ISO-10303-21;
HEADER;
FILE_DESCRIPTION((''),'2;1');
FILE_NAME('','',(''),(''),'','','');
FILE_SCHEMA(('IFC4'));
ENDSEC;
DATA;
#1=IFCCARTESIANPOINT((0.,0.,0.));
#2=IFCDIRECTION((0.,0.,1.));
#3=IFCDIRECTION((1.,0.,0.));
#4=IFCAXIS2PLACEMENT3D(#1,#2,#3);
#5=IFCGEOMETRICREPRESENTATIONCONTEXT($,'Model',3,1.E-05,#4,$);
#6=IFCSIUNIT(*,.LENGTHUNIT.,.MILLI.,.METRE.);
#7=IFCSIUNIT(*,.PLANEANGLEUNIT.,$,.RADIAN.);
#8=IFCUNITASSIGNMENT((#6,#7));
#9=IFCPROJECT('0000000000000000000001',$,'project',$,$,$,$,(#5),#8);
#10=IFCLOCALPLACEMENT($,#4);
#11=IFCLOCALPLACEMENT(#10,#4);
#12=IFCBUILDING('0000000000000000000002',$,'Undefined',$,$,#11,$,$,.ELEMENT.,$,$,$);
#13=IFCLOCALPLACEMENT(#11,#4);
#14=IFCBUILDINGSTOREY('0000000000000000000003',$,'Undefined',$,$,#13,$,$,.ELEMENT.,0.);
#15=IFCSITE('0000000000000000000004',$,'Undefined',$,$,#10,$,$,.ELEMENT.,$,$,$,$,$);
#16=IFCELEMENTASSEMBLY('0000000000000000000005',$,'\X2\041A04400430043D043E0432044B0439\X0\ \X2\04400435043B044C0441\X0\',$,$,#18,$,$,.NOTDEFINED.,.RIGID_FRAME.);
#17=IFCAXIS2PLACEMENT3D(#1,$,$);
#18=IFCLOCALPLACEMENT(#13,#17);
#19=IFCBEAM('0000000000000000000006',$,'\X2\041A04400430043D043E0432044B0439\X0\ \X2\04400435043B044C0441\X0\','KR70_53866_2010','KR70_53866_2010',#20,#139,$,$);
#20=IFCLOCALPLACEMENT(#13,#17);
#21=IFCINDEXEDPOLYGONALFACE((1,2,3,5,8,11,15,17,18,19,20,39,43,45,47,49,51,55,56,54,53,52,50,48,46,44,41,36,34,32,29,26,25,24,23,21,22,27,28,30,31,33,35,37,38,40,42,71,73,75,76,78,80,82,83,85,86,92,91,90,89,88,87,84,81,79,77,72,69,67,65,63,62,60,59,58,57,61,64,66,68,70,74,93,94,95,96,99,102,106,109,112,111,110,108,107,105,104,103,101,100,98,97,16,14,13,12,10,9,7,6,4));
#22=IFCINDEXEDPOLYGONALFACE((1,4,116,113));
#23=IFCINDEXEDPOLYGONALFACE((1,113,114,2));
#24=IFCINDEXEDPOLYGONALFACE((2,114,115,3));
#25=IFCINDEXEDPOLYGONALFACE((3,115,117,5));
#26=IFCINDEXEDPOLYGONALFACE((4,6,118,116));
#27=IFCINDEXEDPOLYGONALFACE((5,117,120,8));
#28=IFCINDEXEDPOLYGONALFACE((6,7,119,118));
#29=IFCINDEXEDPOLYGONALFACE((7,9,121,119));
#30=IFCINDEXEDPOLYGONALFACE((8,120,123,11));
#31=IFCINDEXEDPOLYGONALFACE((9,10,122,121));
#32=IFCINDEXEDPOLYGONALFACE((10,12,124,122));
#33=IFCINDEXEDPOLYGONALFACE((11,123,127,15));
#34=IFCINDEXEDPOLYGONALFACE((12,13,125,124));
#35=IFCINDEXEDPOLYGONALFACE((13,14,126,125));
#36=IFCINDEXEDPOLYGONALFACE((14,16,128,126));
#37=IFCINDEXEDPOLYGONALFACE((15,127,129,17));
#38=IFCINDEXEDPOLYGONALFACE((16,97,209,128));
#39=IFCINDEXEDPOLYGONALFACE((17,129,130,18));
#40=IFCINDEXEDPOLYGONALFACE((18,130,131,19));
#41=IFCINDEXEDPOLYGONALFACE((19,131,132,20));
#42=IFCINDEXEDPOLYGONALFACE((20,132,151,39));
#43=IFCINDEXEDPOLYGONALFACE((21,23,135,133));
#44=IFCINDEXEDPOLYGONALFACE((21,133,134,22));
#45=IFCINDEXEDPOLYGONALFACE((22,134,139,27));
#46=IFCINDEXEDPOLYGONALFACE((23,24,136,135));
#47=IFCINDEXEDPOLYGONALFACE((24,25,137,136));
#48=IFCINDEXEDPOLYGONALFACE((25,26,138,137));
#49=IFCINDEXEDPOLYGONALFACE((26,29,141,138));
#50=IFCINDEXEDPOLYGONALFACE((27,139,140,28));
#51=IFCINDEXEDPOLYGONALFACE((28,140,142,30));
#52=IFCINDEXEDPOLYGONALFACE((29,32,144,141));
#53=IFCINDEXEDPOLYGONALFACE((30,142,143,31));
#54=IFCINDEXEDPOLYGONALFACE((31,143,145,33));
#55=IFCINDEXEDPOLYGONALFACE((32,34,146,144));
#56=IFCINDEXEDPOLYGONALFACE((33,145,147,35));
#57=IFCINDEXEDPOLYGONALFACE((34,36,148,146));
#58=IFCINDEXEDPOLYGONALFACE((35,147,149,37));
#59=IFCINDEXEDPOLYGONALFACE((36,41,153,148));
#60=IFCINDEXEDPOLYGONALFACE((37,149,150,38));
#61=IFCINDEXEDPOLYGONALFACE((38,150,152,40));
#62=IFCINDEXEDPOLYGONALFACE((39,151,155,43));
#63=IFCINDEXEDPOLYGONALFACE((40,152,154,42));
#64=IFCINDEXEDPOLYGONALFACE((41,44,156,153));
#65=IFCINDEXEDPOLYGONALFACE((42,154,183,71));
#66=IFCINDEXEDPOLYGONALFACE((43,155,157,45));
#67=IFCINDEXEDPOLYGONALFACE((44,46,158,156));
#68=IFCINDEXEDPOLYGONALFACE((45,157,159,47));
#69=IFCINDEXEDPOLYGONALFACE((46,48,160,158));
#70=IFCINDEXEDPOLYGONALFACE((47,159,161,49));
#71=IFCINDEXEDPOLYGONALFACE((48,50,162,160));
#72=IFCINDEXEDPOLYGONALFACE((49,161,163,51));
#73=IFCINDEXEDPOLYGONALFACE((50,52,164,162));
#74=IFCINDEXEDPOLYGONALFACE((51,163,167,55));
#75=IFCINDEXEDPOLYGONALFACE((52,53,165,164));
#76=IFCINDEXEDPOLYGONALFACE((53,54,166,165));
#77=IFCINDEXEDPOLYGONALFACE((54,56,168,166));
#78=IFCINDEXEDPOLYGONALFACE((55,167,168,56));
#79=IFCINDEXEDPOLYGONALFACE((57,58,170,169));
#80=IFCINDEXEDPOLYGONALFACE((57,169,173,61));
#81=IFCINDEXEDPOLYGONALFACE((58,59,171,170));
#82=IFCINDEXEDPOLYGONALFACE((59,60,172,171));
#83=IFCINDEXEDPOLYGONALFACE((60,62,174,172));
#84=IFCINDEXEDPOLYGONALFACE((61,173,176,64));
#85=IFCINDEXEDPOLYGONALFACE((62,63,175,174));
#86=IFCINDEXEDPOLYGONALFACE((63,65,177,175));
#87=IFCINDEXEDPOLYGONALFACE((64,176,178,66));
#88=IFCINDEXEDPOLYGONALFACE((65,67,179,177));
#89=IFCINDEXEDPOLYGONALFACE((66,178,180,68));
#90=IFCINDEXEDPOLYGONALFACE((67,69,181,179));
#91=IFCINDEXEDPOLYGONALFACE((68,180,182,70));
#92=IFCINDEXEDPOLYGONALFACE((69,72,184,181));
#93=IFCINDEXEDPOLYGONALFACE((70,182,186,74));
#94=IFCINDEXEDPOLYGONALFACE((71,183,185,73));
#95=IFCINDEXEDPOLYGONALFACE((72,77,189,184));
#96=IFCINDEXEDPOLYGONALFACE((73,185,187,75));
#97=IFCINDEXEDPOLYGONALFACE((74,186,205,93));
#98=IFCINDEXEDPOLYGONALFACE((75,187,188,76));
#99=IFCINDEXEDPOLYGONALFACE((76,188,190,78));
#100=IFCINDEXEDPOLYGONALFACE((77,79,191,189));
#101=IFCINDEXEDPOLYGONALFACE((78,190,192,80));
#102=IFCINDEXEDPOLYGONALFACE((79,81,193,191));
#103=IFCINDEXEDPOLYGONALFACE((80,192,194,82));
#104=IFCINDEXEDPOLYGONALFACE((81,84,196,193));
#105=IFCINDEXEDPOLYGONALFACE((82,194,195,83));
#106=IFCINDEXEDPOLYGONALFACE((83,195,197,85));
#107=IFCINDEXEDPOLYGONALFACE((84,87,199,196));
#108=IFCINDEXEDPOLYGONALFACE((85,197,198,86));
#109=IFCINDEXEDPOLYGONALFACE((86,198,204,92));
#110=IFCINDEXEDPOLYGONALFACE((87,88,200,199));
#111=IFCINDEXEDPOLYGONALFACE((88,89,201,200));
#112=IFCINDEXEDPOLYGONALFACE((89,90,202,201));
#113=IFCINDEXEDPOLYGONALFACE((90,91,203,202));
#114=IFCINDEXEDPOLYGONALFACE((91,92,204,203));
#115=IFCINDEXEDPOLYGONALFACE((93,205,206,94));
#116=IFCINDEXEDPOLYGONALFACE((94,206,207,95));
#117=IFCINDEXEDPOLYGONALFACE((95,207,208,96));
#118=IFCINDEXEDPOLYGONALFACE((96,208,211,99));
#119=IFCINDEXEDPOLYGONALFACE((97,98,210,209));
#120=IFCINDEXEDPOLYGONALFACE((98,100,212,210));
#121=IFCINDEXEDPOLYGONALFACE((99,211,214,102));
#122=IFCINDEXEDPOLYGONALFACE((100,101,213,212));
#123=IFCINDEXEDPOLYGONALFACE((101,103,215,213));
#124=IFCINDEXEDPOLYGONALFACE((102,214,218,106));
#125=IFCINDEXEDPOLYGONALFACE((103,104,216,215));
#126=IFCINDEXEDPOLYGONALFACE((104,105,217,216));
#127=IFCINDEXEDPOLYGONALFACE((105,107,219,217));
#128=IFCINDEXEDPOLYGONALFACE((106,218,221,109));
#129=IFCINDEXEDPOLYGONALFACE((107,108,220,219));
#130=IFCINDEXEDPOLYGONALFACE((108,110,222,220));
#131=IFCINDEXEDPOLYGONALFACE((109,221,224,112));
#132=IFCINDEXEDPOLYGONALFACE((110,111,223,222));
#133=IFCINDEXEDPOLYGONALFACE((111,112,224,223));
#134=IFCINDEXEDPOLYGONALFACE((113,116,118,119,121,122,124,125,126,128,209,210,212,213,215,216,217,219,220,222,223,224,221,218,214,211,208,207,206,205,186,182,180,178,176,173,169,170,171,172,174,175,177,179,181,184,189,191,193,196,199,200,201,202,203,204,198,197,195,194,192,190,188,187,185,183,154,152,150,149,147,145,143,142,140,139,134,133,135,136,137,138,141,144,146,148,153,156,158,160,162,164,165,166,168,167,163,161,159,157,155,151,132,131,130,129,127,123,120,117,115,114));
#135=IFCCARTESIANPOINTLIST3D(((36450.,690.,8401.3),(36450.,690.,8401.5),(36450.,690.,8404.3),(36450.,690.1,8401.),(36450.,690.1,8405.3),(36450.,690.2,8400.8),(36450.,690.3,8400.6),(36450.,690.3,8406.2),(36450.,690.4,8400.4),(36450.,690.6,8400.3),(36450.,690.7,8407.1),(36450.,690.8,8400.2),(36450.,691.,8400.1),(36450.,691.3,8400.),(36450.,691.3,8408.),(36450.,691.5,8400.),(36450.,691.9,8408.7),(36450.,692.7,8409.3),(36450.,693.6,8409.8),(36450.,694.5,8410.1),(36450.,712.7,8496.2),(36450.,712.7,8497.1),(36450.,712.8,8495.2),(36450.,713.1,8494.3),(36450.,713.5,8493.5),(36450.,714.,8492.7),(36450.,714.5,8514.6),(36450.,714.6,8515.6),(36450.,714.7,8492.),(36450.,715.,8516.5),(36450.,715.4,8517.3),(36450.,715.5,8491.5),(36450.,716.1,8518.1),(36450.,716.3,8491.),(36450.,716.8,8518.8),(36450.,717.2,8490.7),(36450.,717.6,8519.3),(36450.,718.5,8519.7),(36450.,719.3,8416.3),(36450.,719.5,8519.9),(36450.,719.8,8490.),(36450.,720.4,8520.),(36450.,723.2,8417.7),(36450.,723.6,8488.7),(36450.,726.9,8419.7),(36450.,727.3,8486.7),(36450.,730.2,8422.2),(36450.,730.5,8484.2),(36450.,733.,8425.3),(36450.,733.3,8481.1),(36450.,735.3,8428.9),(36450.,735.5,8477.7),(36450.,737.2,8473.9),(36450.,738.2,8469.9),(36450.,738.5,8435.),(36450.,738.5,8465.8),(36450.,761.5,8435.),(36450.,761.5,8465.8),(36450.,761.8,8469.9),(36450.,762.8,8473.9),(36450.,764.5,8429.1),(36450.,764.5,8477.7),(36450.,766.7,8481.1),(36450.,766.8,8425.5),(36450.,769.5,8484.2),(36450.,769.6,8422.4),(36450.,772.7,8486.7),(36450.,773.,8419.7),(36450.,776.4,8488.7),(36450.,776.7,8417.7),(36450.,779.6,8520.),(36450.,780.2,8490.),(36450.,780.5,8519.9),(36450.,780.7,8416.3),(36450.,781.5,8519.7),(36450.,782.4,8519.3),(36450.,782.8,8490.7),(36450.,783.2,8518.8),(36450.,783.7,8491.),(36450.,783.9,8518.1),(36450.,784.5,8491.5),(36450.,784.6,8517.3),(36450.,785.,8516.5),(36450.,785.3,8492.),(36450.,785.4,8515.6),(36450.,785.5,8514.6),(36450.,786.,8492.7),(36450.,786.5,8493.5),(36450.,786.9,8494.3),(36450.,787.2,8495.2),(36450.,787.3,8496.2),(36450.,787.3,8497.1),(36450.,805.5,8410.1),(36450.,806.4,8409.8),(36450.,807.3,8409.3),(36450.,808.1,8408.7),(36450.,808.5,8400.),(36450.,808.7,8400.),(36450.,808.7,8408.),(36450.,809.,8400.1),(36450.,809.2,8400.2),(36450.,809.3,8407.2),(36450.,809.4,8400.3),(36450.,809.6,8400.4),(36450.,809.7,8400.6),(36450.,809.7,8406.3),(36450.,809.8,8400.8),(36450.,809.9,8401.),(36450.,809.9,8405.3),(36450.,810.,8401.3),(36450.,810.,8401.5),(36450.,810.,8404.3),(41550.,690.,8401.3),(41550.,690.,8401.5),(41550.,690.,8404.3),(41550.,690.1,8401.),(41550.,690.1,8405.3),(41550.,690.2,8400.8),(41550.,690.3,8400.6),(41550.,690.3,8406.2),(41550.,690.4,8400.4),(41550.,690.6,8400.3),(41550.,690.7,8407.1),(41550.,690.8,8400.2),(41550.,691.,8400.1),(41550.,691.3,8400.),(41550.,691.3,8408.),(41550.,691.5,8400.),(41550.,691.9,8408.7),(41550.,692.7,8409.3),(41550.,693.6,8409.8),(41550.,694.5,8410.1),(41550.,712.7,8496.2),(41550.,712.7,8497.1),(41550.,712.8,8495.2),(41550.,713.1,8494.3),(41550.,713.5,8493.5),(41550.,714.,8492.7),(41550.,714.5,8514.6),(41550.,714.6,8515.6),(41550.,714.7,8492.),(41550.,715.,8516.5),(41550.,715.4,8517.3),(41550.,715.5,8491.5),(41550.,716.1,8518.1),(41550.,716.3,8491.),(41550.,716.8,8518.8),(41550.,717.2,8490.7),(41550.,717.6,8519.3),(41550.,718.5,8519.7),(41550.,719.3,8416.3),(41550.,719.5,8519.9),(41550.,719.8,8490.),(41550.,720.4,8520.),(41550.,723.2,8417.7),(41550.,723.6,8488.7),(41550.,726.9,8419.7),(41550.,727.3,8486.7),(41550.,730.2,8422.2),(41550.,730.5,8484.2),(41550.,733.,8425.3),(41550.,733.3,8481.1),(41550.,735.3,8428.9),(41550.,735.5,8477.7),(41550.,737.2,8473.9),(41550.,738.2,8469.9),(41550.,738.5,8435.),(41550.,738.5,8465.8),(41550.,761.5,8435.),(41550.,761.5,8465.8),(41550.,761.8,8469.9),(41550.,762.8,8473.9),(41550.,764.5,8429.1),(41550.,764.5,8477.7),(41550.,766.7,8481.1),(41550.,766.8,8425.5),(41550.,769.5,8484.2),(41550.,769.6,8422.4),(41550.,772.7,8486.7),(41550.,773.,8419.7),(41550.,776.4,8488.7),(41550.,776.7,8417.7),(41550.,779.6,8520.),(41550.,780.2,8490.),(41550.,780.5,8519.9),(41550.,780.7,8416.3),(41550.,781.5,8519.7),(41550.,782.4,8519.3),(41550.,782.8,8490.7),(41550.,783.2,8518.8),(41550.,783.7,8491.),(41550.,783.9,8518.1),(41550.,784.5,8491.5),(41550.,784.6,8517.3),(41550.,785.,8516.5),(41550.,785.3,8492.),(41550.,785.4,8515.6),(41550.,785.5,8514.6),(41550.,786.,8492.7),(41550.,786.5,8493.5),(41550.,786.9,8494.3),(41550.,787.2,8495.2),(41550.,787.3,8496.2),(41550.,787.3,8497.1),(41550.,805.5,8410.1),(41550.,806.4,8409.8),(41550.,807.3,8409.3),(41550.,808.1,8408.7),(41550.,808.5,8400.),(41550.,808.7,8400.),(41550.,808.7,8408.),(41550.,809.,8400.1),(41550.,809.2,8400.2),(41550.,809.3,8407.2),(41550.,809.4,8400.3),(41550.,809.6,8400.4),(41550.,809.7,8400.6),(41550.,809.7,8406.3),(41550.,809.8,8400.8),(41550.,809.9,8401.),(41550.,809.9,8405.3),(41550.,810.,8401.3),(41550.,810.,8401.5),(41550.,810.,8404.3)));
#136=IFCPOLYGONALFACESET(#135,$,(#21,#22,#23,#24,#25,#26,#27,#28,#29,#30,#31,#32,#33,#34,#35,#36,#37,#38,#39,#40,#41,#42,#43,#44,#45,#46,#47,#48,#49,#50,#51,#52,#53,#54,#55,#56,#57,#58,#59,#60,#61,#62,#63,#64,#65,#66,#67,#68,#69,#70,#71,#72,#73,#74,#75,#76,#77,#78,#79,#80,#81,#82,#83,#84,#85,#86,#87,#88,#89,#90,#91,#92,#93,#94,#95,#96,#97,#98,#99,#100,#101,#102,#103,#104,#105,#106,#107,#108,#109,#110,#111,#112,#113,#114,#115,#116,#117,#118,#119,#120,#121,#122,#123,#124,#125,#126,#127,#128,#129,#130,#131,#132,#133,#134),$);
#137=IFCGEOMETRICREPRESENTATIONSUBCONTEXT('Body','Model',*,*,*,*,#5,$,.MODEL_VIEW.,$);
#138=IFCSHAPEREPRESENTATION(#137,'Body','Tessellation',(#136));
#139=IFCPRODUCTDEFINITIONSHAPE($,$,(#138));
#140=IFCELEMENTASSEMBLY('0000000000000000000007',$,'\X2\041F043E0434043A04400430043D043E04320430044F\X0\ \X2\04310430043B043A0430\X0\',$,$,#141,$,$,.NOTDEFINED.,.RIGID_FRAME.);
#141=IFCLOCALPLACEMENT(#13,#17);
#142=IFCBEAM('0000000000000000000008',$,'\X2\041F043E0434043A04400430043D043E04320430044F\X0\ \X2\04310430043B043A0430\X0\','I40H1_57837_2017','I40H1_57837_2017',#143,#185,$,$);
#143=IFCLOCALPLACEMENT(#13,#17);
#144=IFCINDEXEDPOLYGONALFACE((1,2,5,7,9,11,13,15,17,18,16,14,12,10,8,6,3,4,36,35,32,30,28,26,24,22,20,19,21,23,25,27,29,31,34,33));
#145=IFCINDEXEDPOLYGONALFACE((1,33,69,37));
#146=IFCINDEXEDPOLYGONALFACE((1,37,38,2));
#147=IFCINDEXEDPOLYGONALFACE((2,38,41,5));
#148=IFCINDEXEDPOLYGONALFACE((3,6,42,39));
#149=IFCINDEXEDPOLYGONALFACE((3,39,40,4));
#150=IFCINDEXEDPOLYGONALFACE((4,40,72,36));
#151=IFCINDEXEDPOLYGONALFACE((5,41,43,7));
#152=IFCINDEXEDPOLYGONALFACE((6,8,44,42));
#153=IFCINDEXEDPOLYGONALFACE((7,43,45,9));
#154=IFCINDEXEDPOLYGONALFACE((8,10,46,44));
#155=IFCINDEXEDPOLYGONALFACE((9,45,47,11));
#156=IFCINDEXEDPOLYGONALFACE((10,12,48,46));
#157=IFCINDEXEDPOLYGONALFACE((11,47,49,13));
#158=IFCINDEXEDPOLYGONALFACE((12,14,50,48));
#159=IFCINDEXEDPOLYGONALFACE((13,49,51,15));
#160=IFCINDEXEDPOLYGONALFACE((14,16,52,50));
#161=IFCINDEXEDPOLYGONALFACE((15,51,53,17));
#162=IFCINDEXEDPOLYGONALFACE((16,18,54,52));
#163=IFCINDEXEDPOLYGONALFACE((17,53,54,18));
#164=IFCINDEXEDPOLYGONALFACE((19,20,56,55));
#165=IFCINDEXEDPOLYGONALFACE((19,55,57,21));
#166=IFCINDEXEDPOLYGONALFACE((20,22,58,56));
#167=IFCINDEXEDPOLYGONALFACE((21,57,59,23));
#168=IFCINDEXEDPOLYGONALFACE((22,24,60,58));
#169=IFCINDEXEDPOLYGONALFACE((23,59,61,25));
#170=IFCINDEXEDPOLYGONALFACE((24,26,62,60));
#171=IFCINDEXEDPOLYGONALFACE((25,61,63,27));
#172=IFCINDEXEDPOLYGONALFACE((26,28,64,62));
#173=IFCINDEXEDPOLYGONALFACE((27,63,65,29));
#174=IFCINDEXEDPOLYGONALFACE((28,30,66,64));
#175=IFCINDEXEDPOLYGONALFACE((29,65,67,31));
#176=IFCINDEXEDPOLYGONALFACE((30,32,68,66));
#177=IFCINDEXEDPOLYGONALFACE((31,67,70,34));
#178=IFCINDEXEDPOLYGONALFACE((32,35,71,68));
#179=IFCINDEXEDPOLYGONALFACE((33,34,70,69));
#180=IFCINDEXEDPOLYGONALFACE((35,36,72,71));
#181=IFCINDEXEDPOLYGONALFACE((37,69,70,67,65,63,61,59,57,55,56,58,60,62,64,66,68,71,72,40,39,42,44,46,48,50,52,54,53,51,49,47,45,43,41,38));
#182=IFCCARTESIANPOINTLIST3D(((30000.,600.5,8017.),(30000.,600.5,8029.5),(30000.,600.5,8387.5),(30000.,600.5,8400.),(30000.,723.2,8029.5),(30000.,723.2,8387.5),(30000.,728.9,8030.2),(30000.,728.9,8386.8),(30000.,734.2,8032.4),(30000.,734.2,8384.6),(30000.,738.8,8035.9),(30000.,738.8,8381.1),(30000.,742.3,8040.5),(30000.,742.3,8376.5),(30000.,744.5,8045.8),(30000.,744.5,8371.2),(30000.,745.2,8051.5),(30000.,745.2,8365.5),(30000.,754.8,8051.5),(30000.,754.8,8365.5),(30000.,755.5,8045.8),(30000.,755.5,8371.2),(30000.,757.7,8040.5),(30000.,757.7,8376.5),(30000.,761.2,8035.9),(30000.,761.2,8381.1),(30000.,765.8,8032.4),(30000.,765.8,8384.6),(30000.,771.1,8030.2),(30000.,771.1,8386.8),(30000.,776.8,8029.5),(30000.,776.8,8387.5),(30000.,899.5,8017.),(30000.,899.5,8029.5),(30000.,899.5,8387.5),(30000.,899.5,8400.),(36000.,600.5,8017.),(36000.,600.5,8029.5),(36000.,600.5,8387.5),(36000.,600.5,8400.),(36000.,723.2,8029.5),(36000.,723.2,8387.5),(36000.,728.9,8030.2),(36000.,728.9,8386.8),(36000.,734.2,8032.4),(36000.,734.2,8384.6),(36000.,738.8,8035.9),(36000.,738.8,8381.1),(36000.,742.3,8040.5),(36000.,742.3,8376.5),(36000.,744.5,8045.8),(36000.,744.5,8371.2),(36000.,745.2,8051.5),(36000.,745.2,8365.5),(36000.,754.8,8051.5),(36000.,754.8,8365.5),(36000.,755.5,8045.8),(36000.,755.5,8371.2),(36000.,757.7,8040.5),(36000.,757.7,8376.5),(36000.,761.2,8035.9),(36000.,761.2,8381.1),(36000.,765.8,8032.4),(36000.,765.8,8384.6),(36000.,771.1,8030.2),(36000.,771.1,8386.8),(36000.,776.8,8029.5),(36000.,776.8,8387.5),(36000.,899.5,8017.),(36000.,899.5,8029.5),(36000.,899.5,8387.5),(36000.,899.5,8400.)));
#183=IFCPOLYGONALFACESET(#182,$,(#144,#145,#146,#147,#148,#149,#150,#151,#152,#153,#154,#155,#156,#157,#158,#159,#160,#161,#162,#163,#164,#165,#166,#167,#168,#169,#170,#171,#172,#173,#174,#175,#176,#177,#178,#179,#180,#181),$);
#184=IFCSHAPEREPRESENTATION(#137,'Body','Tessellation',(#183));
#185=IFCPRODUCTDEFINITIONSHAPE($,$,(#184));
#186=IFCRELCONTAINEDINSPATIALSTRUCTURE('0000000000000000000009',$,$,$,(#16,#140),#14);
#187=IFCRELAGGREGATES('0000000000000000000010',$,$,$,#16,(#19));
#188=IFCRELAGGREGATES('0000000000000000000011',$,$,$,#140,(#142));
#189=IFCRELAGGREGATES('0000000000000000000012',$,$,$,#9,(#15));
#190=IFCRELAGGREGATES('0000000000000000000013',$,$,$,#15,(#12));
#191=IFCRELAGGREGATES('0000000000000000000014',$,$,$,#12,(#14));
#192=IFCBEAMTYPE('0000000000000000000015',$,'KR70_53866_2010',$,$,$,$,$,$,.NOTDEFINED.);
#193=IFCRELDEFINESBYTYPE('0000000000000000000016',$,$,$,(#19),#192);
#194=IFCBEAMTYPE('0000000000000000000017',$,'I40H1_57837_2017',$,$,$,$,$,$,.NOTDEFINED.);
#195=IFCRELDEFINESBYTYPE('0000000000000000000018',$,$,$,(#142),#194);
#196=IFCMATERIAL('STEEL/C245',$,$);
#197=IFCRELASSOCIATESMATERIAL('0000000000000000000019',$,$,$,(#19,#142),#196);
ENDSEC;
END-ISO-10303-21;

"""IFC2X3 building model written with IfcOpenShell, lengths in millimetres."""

from ifc_helpers import new_model, si_unit, frame, origin_with_axes, origin_2d_with_axis, place, context, subcontext, project, spatial, polyline, i_section, outline, extrude, material, type_object, element, aggregate, save


model = new_model("IFC2X3")

# Units and contexts
model_context = context("Model", 3, precision=1e-05, world=origin_with_axes())
body_context = subcontext(model_context, "Body", "Model", "MODEL_VIEW")
ifc_project = project(units=[si_unit("LENGTHUNIT", "METRE", prefix="MILLI"), si_unit("PLANEANGLEUNIT", "RADIAN")], contexts=[model_context])

# Site, building, storey
site_placement = place(None, origin_with_axes())
site = spatial("IfcSite", under=ifc_project, at=site_placement, Name="Undefined", CompositionType="ELEMENT")
building_placement = place(site_placement, origin_with_axes())
building = spatial("IfcBuilding", under=site, at=building_placement, Name="Undefined", CompositionType="ELEMENT")
storey_placement = place(building_placement, origin_with_axes())
storey = spatial("IfcBuildingStorey", under=building, at=storey_placement, Name="Undefined", CompositionType="ELEMENT", Elevation=0.0)

# Shared definitions
ifc_material_1 = material(Name="STEEL/C245")

# Element assemblies, beams
assembly_1_placement = place(storey_placement, origin_with_axes())
assembly_1 = element("IfcElementAssembly", 1, at=assembly_1_placement, inside=storey, Name="Крановый рельс", AssemblyPlace="NOTDEFINED", PredefinedType="RIGID_FRAME")
beam_type_1 = type_object("IfcBeamType", Name="KR70_53866_2010", PredefinedType="NOTDEFINED")
beam_1_placement = place(assembly_1_placement, frame((36450.0, 750.0, 8460.0), z_axis=(0.0, 0.0, 1.0), x_axis=(1.0, 0.0, 0.0)))
beam_1 = element("IfcBeam", 2, at=beam_1_placement, type_object=beam_type_1, material=ifc_material_1, Name="Крановый рельс", Description="KR70_53866_2010", ObjectType="KR70_53866_2010", context=body_context, shape_type="SweptSolid", body=[
    extrude(outline(polyline([(58.7, -52.0), (59.3, -52.9), (59.7, -53.8), (59.9, -54.7), (60.0, -55.7), (60.0, -58.5), (60.0, -58.7), (59.9, -59.0), (59.8, -59.2), (59.7, -59.4), (59.6, -59.6), (59.4, -59.7), (59.2, -59.8), (59.0, -59.9), (58.7, -60.0), (58.5, -60.0), (-58.5, -60.0), (-58.7, -60.0), (-59.0, -59.9), (-59.2, -59.8), (-59.4, -59.7), (-59.6, -59.6), (-59.7, -59.4), (-59.8, -59.2), (-59.9, -59.0), (-60.0, -58.7), (-60.0, -58.5), (-60.0, -55.7), (-59.9, -54.7), (-59.7, -53.7), (-59.3, -52.8), (-58.7, -52.0), (-58.1, -51.3), (-57.3, -50.7), (-56.4, -50.2), (-55.5, -49.9), (-30.7, -43.7), (-26.7, -42.3), (-23.0, -40.3), (-19.6, -37.6), (-16.8, -34.5), (-14.5, -30.9), (-11.5, -25.0), (-11.5, 5.8), (-11.8, 9.9), (-12.8, 13.9), (-14.5, 17.7), (-16.7, 21.1), (-19.5, 24.2), (-22.7, 26.7), (-26.4, 28.7), (-30.2, 30.0), (-32.8, 30.7), (-33.7, 31.0), (-34.5, 31.5), (-35.3, 32.0), (-36.0, 32.7), (-36.5, 33.5), (-36.9, 34.3), (-37.2, 35.2), (-37.3, 36.2), (-37.3, 37.1), (-35.5, 54.6), (-35.4, 55.6), (-35.0, 56.5), (-34.6, 57.3), (-33.9, 58.1), (-33.2, 58.8), (-32.4, 59.3), (-31.5, 59.7), (-30.5, 59.9), (-29.6, 60.0), (29.6, 60.0), (30.5, 59.9), (31.5, 59.7), (32.4, 59.3), (33.2, 58.8), (33.9, 58.1), (34.6, 57.3), (35.0, 56.5), (35.4, 55.6), (35.5, 54.6), (37.3, 37.1), (37.3, 36.2), (37.2, 35.2), (36.9, 34.3), (36.5, 33.5), (36.0, 32.7), (35.3, 32.0), (34.5, 31.5), (33.7, 31.0), (32.8, 30.7), (30.2, 30.0), (26.4, 28.7), (22.7, 26.7), (19.5, 24.2), (16.7, 21.1), (14.5, 17.7), (12.8, 13.9), (11.8, 9.9), (11.5, 5.8), (11.5, -25.0), (14.7, -31.1), (17.0, -34.7), (19.8, -37.8), (23.1, -40.3), (26.8, -42.3), (30.7, -43.7), (55.5, -49.9), (56.4, -50.2), (57.3, -50.7), (58.1, -51.3), (58.7, -52.0)])), frame((5100.0, 0.0, 0.0), z_axis=(-1.0, 0.0, 0.0), x_axis=(0.0, -1.0, 0.0)), (0.0, 0.0, 1.0), 5100.0),
])
aggregate(assembly_1, [beam_1])
assembly_2_placement = place(storey_placement, origin_with_axes())
assembly_2 = element("IfcElementAssembly", 3, at=assembly_2_placement, inside=storey, Name="Подкрановая балка", AssemblyPlace="NOTDEFINED", PredefinedType="RIGID_FRAME")
beam_type_2 = type_object("IfcBeamType", Name="I40H1_57837_2017", PredefinedType="NOTDEFINED")
beam_2_placement = place(assembly_2_placement, frame((36000.0, 750.0, 8208.5), z_axis=(0.0, 0.0, 1.0), x_axis=(-1.0, 0.0, 0.0)))
beam_2 = element("IfcBeam", 4, at=beam_2_placement, type_object=beam_type_2, material=ifc_material_1, Name="Подкрановая балка", Description="I40H1_57837_2017", ObjectType="I40H1_57837_2017", context=body_context, shape_type="SweptSolid", body=[
    extrude(i_section(OverallWidth=299.0, OverallDepth=383.0, WebThickness=9.5, FlangeThickness=12.5, FilletRadius=22.0, at=origin_2d_with_axis()), frame((6000.0, 0.0, 0.0), z_axis=(-1.0, 0.0, 0.0), x_axis=(0.0, -1.0, 0.0)), (0.0, 0.0, 1.0), 6000.0),
])
aggregate(assembly_2, [beam_2])

save(model, "model.ifc")
